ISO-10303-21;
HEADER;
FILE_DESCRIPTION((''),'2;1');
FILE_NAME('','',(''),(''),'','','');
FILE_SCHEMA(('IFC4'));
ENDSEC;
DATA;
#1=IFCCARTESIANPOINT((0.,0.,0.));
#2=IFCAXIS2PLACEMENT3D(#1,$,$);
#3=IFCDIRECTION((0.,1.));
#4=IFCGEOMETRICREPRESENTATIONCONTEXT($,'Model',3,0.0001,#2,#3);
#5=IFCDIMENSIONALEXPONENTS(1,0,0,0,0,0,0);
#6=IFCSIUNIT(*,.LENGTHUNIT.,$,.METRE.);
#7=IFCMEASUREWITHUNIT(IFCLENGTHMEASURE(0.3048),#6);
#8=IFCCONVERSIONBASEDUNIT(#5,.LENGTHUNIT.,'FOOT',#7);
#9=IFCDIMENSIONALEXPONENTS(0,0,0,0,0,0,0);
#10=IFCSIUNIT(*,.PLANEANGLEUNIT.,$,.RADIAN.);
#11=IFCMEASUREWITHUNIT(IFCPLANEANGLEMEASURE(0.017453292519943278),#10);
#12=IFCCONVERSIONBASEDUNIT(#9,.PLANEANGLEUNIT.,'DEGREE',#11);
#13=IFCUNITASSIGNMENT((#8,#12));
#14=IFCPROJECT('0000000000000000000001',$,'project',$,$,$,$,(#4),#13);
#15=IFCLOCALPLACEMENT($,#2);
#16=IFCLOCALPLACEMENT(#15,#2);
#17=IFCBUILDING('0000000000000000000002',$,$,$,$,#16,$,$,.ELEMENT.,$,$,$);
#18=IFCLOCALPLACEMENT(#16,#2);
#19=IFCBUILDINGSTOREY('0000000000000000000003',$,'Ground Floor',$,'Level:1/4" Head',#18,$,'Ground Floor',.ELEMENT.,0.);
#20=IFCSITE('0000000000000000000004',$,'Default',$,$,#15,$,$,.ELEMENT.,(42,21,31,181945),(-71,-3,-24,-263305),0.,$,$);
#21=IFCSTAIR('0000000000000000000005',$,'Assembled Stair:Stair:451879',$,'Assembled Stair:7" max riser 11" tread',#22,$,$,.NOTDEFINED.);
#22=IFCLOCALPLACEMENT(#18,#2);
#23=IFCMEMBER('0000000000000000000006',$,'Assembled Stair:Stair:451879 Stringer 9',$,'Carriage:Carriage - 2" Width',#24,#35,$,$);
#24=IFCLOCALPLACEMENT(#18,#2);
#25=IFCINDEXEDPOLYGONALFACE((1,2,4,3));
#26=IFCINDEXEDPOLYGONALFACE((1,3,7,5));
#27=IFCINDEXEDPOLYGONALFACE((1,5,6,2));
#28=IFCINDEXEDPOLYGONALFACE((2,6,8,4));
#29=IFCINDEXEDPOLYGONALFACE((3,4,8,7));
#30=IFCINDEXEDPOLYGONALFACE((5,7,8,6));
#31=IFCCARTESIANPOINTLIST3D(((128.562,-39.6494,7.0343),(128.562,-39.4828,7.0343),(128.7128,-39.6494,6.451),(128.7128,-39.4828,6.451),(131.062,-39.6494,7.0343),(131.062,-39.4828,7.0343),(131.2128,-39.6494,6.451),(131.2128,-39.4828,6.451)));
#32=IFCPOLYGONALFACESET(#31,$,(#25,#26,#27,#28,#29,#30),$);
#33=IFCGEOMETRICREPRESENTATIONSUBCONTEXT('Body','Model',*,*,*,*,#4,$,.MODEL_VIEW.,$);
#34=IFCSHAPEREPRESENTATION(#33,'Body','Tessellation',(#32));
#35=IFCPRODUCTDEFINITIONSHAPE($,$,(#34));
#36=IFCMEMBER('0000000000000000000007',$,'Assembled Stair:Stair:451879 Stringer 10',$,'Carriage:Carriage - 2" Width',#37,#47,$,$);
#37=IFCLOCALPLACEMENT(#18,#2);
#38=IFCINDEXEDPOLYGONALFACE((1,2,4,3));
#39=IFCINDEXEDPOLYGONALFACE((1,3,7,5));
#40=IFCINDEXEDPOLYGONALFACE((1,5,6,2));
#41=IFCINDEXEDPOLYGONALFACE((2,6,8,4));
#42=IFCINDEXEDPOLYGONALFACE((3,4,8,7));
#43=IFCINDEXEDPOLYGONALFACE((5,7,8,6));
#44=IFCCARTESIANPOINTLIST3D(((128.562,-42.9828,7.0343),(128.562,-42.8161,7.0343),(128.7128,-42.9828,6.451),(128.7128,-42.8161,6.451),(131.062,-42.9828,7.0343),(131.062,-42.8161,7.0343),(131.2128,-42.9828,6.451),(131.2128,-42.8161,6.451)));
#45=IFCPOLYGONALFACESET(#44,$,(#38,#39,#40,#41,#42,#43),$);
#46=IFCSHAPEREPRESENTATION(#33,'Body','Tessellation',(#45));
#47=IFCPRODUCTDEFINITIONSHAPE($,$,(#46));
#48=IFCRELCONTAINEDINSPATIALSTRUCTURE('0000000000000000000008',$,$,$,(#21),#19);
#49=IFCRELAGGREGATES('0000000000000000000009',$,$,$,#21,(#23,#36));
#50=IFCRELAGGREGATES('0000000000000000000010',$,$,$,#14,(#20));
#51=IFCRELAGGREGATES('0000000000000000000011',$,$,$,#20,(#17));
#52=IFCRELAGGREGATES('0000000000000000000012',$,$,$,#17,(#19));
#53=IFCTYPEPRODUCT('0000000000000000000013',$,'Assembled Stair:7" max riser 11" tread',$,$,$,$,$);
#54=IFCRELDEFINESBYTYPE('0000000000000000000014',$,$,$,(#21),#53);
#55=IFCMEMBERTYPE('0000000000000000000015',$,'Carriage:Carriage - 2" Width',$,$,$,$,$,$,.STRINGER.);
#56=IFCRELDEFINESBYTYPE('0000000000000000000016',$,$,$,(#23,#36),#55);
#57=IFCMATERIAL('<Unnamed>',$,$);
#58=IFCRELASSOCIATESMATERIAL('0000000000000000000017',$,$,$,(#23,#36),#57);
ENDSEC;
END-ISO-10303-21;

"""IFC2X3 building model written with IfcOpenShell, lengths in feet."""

from ifc_helpers import new_model, entity, si_unit, converted_unit, direction, frame, origin, place, context, subcontext, project, spatial, polyline, outline, extrude, material, type_object, element, aggregate, save


model = new_model("IFC2X3")

# Units and contexts
model_context = context("Model", 3, precision=0.0001, world=origin(), true_north=direction((0.0, 1.0)))
body_context = subcontext(model_context, "Body", "Model", "MODEL_VIEW")
ifc_project = project(units=[converted_unit("LENGTHUNIT", "FOOT", entity("IfcLengthMeasure", 0.3048), si_unit("LENGTHUNIT", "METRE"), dimensions=[1, 0, 0, 0, 0, 0, 0]), converted_unit("PLANEANGLEUNIT", "DEGREE", entity("IfcPlaneAngleMeasure", 0.017453292519943278), si_unit("PLANEANGLEUNIT", "RADIAN"), dimensions=[0, 0, 0, 0, 0, 0, 0])], contexts=[model_context])

# Site, building, storey
site_placement = place(None, origin())
site = spatial("IfcSite", under=ifc_project, at=site_placement, Name="Default", CompositionType="ELEMENT", RefLatitude=(42, 21, 31, 181945), RefLongitude=(-71, -3, -24, -263305), RefElevation=0.0)
building_placement = place(site_placement, origin())
building = spatial("IfcBuilding", under=site, at=building_placement, CompositionType="ELEMENT")
storey_placement = place(building_placement, origin())
storey = spatial("IfcBuildingStorey", under=building, at=storey_placement, Name="Ground Floor", ObjectType="Level:1/4\" Head", LongName="Ground Floor", CompositionType="ELEMENT", Elevation=0.0)

# Stair, members
ifc_material_1 = material(Name="<Unnamed>")
member_type = type_object("IfcMemberType", Name="Carriage:Carriage - 2\" Width", PredefinedType="STRINGER")
type_product_1 = type_object("IfcTypeProduct", Name="Assembled Stair:7\" max riser 11\" tread")
stair_1_placement = place(storey_placement, origin())
stair_1 = element("IfcStair", 1, at=stair_1_placement, inside=storey, type_object=type_product_1, Name="Assembled Stair:Stair:451879", ObjectType="Assembled Stair:7\" max riser 11\" tread", ShapeType="NOTDEFINED")
member_1_placement = place(stair_1_placement, origin())
member_1 = element("IfcMember", 2, at=member_1_placement, type_object=member_type, material=ifc_material_1, Name="Assembled Stair:Stair:451879 Stringer 9", ObjectType="Carriage:Carriage - 2\" Width", context=body_context, shape_type="SweptSolid", body=[
    extrude(outline(polyline([(0.0115, -1.2102), (0.614, -1.2102), (-0.0115, 1.2102), (-0.614, 1.2102), (0.0115, -1.2102)])), frame((129.8874, -39.6494, 6.7426), z_axis=(0.0, 1.0, 0.0), x_axis=(-0.250236, 0.0, 0.968185)), (0.0, 0.0, 1.0), 0.1667),
])
member_2_placement = place(stair_1_placement, origin())
member_2 = element("IfcMember", 3, at=member_2_placement, type_object=member_type, material=ifc_material_1, Name="Assembled Stair:Stair:451879 Stringer 10", ObjectType="Carriage:Carriage - 2\" Width", context=body_context, shape_type="SweptSolid", body=[
    extrude(outline(polyline([(0.0115, -1.2102), (0.614, -1.2102), (-0.0115, 1.2102), (-0.614, 1.2102), (0.0115, -1.2102)])), frame((129.8874, -42.9828, 6.7426), z_axis=(0.0, 1.0, 0.0), x_axis=(-0.250236, 0.0, 0.968185)), (0.0, 0.0, 1.0), 0.1667),
])

aggregate(stair_1, [member_1, member_2])

save(model, "model.ifc")
